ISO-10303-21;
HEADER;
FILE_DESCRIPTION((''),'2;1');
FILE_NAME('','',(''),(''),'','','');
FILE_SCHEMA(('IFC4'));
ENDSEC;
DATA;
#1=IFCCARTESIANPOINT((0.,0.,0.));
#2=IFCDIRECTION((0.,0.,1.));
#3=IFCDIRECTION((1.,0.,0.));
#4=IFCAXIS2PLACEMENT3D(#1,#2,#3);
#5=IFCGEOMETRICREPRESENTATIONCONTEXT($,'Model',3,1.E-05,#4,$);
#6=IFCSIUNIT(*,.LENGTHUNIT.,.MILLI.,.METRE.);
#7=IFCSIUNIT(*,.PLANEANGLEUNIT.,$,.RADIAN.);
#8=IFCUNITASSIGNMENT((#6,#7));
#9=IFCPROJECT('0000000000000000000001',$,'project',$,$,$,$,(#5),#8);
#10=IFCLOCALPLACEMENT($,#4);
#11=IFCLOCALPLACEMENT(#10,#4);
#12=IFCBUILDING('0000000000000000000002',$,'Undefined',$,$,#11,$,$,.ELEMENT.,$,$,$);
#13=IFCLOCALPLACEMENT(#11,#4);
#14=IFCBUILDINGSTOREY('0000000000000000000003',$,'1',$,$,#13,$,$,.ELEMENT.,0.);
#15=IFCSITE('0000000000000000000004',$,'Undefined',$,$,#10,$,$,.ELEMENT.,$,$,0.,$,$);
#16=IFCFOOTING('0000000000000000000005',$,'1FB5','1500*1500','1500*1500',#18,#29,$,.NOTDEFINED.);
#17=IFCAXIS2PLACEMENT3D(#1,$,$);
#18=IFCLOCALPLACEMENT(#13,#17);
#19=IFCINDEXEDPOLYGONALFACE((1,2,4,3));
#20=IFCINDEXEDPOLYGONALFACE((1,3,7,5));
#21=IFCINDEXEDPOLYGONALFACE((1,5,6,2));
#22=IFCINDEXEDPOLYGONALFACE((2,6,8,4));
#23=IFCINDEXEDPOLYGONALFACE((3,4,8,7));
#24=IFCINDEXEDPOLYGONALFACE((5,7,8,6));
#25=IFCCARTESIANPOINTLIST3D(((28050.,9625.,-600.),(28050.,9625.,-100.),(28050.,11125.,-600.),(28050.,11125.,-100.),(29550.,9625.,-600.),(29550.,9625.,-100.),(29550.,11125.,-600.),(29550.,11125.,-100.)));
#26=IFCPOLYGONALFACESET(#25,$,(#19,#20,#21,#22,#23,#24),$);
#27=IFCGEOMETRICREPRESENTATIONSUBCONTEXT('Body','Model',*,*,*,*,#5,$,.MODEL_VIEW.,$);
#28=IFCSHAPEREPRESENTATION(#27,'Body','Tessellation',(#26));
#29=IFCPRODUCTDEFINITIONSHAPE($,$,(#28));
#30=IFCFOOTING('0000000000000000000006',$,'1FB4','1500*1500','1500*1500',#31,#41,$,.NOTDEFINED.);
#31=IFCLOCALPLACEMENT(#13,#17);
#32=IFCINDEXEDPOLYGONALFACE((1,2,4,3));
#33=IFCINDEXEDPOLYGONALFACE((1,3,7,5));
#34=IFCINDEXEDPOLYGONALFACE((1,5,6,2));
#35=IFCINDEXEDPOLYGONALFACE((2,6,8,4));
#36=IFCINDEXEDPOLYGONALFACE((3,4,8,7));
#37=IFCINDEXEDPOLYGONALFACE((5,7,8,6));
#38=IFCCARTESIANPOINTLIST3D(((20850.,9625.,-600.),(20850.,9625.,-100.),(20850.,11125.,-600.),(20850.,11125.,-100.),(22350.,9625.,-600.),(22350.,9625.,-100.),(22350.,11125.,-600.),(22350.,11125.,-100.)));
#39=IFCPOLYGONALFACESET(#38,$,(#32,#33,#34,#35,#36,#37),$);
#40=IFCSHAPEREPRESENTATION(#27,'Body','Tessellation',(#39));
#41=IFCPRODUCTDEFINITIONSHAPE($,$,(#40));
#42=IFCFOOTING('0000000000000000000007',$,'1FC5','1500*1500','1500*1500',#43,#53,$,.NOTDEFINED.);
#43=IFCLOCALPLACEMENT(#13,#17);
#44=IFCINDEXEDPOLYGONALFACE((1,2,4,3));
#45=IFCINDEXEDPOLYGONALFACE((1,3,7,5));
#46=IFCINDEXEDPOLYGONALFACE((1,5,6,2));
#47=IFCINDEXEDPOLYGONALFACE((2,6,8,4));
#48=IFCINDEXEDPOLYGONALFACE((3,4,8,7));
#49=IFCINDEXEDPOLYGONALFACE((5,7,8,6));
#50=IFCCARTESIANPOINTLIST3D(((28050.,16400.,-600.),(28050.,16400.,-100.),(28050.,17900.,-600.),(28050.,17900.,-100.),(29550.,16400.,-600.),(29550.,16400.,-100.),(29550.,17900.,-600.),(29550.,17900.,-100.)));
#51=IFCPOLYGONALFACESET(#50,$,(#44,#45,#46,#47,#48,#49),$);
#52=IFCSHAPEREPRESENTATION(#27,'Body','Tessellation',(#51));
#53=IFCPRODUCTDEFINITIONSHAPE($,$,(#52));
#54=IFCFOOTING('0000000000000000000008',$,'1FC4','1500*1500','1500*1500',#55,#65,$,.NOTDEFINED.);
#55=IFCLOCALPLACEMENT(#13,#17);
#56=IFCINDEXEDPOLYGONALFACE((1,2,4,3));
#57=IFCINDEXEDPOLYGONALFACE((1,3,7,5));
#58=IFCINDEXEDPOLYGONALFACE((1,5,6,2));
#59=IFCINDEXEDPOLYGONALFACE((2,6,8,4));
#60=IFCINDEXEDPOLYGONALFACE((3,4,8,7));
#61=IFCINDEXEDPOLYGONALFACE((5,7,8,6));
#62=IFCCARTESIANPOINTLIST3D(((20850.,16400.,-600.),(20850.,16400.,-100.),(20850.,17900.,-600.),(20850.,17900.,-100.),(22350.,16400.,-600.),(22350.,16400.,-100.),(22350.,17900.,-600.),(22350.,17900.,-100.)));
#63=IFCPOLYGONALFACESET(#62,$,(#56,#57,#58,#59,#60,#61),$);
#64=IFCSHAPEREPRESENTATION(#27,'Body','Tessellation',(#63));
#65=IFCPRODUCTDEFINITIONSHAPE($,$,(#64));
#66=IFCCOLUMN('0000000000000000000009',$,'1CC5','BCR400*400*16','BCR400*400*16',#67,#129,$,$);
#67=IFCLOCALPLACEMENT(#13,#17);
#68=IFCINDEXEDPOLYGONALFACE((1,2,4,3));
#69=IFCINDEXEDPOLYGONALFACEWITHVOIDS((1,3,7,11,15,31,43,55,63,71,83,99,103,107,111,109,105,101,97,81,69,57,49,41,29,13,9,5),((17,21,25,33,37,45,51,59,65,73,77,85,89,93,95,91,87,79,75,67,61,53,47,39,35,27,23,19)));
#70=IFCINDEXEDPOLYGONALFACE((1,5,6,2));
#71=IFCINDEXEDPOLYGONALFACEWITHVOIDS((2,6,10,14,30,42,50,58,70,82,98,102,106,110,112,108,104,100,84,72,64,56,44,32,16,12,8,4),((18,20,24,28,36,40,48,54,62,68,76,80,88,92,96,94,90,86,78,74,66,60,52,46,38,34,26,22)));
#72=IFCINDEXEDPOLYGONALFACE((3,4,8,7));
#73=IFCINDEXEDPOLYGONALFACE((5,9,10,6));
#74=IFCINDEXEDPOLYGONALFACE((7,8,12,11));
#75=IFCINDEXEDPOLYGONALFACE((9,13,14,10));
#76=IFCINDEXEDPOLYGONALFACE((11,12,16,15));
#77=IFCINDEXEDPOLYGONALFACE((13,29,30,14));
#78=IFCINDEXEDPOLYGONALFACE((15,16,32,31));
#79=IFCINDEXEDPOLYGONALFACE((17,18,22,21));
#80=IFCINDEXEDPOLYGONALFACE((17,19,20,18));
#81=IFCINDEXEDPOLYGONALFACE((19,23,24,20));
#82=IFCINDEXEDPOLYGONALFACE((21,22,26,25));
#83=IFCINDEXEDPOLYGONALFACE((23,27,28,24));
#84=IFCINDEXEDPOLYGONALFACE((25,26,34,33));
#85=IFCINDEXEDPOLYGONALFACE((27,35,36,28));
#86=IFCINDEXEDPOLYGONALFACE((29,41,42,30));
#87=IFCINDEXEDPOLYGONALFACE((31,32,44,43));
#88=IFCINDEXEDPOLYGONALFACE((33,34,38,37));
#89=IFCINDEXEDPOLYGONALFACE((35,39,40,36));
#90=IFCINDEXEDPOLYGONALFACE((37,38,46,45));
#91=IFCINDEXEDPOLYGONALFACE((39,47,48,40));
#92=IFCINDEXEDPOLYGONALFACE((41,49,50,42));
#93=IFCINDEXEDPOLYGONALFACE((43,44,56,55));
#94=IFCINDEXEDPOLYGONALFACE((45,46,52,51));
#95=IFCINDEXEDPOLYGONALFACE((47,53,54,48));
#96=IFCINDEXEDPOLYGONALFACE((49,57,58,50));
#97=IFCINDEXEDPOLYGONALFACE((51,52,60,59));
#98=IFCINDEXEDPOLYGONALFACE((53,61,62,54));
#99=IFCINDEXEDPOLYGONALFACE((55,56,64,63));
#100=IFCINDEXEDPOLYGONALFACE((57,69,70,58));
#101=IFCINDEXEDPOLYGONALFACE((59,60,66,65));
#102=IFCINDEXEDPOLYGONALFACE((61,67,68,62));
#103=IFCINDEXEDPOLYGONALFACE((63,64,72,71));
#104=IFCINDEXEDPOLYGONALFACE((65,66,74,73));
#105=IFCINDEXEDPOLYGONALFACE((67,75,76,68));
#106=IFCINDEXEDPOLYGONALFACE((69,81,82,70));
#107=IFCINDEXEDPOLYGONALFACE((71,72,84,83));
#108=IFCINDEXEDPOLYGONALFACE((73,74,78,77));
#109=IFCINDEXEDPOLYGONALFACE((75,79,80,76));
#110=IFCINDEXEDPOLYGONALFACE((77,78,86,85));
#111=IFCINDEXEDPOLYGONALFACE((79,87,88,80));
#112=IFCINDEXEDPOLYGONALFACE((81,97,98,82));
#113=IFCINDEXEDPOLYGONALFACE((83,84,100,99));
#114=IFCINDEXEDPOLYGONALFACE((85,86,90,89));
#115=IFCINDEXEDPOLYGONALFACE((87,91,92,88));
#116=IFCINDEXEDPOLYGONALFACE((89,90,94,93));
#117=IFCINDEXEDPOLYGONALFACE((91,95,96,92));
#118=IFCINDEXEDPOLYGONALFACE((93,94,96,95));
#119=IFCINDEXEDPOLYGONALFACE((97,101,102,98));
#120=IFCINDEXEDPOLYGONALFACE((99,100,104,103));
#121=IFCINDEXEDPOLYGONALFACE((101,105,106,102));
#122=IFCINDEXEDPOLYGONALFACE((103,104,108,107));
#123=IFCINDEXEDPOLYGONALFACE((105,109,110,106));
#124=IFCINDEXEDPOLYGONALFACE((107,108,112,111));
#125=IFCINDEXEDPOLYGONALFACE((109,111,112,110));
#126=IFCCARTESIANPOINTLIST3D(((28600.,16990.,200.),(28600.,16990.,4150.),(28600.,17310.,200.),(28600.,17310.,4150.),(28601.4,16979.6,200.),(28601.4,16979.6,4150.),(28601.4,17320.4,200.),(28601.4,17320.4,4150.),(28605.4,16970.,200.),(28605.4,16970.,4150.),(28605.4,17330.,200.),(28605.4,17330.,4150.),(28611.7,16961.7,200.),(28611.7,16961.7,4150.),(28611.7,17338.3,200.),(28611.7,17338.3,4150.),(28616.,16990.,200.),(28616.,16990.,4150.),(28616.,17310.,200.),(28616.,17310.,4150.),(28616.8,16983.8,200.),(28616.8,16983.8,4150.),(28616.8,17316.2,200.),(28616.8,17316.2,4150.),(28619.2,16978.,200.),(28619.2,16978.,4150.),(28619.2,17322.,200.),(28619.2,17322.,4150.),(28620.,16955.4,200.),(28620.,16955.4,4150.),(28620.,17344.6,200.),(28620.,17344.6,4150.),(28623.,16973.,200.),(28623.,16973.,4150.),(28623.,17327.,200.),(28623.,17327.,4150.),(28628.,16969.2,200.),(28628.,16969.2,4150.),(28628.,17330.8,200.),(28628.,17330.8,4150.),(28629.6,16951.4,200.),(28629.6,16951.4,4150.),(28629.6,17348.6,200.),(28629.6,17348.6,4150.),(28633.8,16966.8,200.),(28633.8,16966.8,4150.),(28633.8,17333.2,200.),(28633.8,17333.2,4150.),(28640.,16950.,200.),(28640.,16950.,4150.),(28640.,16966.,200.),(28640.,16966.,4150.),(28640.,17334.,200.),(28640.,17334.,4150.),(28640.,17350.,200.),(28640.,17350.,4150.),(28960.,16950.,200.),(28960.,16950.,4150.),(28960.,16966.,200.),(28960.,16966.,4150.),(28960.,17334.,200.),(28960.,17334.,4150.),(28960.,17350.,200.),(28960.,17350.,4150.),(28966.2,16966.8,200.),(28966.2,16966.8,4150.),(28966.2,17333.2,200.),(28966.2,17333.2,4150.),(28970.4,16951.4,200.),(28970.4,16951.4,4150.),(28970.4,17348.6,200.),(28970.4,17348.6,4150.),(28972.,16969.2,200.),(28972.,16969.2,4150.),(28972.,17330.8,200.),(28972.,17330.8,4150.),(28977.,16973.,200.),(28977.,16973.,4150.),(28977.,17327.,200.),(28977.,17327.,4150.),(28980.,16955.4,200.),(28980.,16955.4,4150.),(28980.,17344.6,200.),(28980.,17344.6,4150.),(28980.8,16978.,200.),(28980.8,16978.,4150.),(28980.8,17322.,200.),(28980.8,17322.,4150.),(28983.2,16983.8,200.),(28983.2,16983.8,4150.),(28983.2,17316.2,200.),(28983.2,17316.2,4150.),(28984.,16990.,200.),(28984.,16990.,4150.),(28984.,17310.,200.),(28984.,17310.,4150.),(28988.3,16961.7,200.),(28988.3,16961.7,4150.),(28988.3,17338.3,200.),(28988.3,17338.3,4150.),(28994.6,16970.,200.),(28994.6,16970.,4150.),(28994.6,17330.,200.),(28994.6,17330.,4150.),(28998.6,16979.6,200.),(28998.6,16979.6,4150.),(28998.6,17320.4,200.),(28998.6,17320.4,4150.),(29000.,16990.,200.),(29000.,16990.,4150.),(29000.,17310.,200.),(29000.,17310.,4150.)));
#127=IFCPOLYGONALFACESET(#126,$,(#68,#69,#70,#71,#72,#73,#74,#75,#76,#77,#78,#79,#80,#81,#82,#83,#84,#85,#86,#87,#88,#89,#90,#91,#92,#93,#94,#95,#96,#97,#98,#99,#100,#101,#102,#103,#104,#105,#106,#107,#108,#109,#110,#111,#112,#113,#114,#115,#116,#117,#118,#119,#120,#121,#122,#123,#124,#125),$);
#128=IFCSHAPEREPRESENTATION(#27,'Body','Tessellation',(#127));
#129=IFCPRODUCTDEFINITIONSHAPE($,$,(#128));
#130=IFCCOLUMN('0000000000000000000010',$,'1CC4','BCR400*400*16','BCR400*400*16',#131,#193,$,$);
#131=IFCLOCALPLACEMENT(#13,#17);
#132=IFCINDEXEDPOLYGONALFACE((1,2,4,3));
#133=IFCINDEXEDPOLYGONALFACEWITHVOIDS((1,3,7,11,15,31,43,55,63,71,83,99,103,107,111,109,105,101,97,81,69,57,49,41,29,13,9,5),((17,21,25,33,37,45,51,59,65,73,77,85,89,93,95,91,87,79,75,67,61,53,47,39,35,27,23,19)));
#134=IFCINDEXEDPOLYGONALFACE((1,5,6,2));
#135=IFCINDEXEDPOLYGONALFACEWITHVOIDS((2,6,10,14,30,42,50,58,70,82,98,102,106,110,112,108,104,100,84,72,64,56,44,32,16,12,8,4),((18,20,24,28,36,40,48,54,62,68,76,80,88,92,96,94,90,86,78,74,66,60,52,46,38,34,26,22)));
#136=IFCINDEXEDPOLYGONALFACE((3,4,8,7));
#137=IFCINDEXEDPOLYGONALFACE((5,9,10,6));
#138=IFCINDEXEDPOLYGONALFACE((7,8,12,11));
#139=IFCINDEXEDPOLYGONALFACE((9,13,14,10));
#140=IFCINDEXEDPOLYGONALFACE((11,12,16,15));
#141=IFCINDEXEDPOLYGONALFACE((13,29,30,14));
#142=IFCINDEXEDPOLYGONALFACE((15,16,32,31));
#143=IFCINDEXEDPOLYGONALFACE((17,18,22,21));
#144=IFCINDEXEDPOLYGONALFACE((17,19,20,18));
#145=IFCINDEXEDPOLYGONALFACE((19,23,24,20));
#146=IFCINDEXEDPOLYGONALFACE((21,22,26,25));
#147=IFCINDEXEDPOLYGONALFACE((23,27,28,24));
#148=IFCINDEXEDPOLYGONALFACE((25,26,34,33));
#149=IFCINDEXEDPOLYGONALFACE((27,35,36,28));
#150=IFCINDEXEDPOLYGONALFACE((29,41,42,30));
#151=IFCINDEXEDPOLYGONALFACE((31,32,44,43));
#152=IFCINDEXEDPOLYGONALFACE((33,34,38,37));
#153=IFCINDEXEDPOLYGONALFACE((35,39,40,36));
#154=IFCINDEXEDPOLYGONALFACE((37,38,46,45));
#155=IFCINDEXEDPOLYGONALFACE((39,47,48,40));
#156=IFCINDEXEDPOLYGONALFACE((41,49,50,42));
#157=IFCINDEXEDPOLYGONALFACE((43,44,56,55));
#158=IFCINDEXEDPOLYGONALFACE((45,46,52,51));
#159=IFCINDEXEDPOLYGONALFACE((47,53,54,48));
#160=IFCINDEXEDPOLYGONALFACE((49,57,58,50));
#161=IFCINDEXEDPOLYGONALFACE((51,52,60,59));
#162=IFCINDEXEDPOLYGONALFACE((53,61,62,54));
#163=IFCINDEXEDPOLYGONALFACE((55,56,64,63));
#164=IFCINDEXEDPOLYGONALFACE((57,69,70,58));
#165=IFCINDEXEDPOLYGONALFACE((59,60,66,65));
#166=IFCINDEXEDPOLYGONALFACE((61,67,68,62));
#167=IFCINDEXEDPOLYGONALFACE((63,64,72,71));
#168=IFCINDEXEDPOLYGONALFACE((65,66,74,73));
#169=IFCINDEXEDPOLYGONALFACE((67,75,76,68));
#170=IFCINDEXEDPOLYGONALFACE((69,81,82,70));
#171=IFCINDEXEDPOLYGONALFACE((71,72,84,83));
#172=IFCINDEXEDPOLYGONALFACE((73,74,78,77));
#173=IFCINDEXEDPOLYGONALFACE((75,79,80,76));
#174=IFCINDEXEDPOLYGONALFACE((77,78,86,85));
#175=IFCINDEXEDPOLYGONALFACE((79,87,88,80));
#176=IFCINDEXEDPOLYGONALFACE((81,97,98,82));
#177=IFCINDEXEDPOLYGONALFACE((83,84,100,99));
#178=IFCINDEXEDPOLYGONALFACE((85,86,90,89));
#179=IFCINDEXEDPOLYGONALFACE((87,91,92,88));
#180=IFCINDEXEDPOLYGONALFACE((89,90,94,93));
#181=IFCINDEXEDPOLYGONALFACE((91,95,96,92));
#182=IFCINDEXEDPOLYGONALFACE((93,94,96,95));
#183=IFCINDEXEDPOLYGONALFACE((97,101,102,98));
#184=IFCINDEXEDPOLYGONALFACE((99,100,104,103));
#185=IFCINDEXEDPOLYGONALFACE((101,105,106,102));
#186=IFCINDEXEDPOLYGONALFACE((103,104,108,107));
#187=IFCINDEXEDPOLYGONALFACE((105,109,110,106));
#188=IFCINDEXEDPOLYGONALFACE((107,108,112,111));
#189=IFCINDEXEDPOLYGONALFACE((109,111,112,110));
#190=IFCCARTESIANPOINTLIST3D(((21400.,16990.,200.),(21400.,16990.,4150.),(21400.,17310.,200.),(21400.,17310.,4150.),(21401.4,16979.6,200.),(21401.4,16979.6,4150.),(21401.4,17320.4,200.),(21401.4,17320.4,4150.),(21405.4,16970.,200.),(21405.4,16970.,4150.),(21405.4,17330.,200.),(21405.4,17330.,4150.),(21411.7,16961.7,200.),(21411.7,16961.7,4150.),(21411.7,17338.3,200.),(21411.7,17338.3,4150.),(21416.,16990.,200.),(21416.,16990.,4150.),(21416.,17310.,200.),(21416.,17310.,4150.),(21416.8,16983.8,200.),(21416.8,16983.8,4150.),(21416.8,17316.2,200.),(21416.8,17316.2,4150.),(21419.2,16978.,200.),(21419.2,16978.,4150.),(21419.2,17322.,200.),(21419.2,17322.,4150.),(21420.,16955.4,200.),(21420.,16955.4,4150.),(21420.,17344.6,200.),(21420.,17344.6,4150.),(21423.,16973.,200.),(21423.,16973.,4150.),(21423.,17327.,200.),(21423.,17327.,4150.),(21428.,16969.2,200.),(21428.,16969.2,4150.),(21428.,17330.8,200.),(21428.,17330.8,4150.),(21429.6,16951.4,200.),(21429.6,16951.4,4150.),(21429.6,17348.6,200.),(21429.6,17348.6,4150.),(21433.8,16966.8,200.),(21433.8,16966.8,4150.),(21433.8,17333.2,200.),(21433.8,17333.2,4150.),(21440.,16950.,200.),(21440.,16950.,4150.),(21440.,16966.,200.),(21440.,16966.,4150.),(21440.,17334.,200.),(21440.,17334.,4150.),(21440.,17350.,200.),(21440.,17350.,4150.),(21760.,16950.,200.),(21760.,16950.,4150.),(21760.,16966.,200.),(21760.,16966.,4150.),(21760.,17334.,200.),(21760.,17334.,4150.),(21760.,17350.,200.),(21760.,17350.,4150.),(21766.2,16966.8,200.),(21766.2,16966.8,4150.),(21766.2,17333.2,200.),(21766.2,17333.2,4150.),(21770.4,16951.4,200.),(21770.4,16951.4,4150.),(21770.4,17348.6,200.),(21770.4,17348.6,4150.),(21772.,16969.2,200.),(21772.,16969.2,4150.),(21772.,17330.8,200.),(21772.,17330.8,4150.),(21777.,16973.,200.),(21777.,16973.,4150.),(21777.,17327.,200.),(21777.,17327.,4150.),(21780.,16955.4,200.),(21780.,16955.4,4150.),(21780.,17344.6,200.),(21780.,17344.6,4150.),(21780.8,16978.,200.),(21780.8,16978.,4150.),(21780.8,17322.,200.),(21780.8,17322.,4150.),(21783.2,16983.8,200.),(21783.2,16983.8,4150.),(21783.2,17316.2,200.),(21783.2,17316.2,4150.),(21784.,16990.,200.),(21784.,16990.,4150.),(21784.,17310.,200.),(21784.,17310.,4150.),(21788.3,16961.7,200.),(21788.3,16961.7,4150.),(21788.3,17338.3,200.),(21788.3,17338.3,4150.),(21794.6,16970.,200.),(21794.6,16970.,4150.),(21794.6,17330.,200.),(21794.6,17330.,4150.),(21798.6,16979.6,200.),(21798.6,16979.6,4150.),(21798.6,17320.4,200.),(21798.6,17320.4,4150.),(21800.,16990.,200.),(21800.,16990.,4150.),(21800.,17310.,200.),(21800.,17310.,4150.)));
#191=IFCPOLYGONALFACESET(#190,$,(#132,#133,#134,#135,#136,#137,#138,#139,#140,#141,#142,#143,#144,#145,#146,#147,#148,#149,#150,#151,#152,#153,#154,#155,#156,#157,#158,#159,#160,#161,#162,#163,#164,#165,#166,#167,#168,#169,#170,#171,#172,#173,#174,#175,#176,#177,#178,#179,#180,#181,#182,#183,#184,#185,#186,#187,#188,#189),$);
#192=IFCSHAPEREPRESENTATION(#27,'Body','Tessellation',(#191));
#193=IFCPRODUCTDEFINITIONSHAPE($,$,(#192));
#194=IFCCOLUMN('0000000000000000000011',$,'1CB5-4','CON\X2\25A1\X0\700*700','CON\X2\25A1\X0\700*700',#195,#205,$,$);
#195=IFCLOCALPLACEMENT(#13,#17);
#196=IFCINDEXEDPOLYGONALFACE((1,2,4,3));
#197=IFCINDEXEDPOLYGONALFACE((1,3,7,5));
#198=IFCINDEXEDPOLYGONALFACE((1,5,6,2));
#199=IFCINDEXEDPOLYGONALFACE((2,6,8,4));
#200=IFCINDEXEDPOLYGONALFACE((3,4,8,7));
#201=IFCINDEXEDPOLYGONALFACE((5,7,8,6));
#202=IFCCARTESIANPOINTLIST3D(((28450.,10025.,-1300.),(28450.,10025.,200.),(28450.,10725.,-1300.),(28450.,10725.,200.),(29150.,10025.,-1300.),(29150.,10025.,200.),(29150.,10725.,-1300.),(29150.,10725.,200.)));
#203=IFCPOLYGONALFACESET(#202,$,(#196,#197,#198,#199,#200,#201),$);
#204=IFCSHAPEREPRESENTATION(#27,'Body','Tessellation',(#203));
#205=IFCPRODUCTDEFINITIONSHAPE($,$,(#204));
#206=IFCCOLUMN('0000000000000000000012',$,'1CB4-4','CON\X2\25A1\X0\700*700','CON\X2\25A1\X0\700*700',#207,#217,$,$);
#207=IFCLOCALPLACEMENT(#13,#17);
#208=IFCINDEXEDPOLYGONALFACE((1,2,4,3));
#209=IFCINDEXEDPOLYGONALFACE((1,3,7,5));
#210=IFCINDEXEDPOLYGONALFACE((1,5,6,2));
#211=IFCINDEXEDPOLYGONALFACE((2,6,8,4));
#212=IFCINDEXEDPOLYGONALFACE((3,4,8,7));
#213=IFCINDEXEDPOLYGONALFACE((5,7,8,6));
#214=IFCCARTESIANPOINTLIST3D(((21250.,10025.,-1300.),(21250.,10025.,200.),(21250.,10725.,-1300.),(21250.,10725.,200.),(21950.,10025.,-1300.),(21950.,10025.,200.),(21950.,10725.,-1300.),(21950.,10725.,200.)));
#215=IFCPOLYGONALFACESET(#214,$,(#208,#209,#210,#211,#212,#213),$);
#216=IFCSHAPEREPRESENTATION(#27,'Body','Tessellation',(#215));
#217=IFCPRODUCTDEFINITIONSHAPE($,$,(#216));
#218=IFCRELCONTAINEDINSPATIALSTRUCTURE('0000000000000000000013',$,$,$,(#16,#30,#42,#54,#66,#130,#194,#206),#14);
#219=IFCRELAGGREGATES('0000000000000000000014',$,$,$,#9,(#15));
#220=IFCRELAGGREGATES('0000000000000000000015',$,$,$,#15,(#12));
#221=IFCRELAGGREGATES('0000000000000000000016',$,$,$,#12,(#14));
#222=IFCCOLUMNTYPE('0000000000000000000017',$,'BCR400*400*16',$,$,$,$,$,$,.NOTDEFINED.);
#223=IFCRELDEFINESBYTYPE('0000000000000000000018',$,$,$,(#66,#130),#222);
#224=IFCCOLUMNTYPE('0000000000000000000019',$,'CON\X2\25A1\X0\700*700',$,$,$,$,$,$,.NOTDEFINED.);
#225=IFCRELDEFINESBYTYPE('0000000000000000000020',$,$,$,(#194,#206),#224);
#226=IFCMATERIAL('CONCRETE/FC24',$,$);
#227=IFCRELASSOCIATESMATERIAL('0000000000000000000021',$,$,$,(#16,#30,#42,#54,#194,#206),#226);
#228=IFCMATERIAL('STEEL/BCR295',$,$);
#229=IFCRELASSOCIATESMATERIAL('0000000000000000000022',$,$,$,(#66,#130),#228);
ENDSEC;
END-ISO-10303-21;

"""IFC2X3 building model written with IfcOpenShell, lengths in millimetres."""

from ifc_helpers import new_model, si_unit, frame, origin_with_axes, origin_2d_with_axis, place, context, subcontext, project, spatial, rectangle, hollow_rectangle, extrude, material, type_object, element, save


model = new_model("IFC2X3")

# Units and contexts
model_context = context("Model", 3, precision=1e-05, world=origin_with_axes())
body_context = subcontext(model_context, "Body", "Model", "MODEL_VIEW")
ifc_project = project(units=[si_unit("LENGTHUNIT", "METRE", prefix="MILLI"), si_unit("PLANEANGLEUNIT", "RADIAN")], contexts=[model_context])

# Site, building, storey
site_placement = place(None, origin_with_axes())
site = spatial("IfcSite", under=ifc_project, at=site_placement, Name="Undefined", CompositionType="ELEMENT", RefElevation=0.0)
building_placement = place(site_placement, origin_with_axes())
building = spatial("IfcBuilding", under=site, at=building_placement, Name="Undefined", CompositionType="ELEMENT")
storey_placement = place(building_placement, origin_with_axes())
storey = spatial("IfcBuildingStorey", under=building, at=storey_placement, Name="1", CompositionType="ELEMENT", Elevation=0.0)

# Footings
ifc_material_1 = material(Name="CONCRETE/FC24")
for number, where, z_axis, x_axis, name in (
    (1, (28800.0, 10375.0, -600.0), (0.0, 1.0, 0.0), (0.0, 0.0, 1.0), "1FB5"),
    (2, (21600.0, 10375.0, -600.0), (0.0, 1.0, 0.0), (0.0, 0.0, 1.0), "1FB4"),
    (3, (28800.0, 17150.0, -600.0), (0.0, 1.0, 0.0), (0.0, 0.0, 1.0), "1FC5"),
    (4, (21600.0, 17150.0, -600.0), (0.0, 1.0, 0.0), (0.0, 0.0, 1.0), "1FC4"),
):
    element("IfcFooting", number, at=place(storey_placement, frame(where, z_axis=z_axis, x_axis=x_axis)), inside=storey, material=ifc_material_1, Name=name, Description="1500*1500", ObjectType="1500*1500", PredefinedType="NOTDEFINED", context=body_context, shape_type="SweptSolid", body=[
        extrude(rectangle(XDim=1500.0, YDim=1500.0, at=origin_2d_with_axis()), frame((500.0, 0.0, 0.0), z_axis=(-1.0, 0.0, 0.0), x_axis=(0.0, -1.0, 0.0)), (0.0, 0.0, 1.0), 500.0),
    ])

# Columns
ifc_material_2 = material(Name="STEEL/BCR295")
column_type_1 = type_object("IfcColumnType", Name="BCR400*400*16", PredefinedType="NOTDEFINED")
for number, where, z_axis, x_axis, name in (
    (5, (28800.0, 17150.0, 200.0), (0.0, 0.0, 1.0), (0.0, 1.0, 0.0), "1CC5"),
    (6, (21600.0, 17150.0, 200.0), (0.0, 0.0, 1.0), (0.0, 1.0, 0.0), "1CC4"),
):
    element("IfcColumn", number, at=place(storey_placement, frame(where, z_axis=z_axis, x_axis=x_axis)), inside=storey, type_object=column_type_1, material=ifc_material_2, Name=name, Description="BCR400*400*16", ObjectType="BCR400*400*16", context=body_context, shape_type="SweptSolid", body=[
        extrude(hollow_rectangle(XDim=400.0, YDim=400.0, WallThickness=16.0, InnerFilletRadius=24.0, OuterFilletRadius=40.0, at=origin_2d_with_axis()), frame((0.0, 0.0, 3950.0), z_axis=(0.0, 0.0, -1.0), x_axis=(0.0, 1.0, 0.0)), (0.0, 0.0, 1.0), 3950.0),
    ])
column_type_2 = type_object("IfcColumnType", Name="CON□700*700", PredefinedType="NOTDEFINED")
for number, where, z_axis, x_axis, name in (
    (7, (28800.0, 10375.0, -1300.0), (0.0, 0.0, 1.0), (0.0, 1.0, 0.0), "1CB5-4"),
    (8, (21600.0, 10375.0, -1300.0), (0.0, 0.0, 1.0), (0.0, 1.0, 0.0), "1CB4-4"),
):
    element("IfcColumn", number, at=place(storey_placement, frame(where, z_axis=z_axis, x_axis=x_axis)), inside=storey, type_object=column_type_2, material=ifc_material_1, Name=name, Description="CON□700*700", ObjectType="CON□700*700", context=body_context, shape_type="SweptSolid", body=[
        extrude(rectangle(XDim=700.0, YDim=700.0, at=origin_2d_with_axis()), frame((0.0, 0.0, 1500.0), z_axis=(0.0, 0.0, -1.0), x_axis=(0.0, 1.0, 0.0)), (0.0, 0.0, 1.0), 1500.0),
    ])

save(model, "model.ifc")
